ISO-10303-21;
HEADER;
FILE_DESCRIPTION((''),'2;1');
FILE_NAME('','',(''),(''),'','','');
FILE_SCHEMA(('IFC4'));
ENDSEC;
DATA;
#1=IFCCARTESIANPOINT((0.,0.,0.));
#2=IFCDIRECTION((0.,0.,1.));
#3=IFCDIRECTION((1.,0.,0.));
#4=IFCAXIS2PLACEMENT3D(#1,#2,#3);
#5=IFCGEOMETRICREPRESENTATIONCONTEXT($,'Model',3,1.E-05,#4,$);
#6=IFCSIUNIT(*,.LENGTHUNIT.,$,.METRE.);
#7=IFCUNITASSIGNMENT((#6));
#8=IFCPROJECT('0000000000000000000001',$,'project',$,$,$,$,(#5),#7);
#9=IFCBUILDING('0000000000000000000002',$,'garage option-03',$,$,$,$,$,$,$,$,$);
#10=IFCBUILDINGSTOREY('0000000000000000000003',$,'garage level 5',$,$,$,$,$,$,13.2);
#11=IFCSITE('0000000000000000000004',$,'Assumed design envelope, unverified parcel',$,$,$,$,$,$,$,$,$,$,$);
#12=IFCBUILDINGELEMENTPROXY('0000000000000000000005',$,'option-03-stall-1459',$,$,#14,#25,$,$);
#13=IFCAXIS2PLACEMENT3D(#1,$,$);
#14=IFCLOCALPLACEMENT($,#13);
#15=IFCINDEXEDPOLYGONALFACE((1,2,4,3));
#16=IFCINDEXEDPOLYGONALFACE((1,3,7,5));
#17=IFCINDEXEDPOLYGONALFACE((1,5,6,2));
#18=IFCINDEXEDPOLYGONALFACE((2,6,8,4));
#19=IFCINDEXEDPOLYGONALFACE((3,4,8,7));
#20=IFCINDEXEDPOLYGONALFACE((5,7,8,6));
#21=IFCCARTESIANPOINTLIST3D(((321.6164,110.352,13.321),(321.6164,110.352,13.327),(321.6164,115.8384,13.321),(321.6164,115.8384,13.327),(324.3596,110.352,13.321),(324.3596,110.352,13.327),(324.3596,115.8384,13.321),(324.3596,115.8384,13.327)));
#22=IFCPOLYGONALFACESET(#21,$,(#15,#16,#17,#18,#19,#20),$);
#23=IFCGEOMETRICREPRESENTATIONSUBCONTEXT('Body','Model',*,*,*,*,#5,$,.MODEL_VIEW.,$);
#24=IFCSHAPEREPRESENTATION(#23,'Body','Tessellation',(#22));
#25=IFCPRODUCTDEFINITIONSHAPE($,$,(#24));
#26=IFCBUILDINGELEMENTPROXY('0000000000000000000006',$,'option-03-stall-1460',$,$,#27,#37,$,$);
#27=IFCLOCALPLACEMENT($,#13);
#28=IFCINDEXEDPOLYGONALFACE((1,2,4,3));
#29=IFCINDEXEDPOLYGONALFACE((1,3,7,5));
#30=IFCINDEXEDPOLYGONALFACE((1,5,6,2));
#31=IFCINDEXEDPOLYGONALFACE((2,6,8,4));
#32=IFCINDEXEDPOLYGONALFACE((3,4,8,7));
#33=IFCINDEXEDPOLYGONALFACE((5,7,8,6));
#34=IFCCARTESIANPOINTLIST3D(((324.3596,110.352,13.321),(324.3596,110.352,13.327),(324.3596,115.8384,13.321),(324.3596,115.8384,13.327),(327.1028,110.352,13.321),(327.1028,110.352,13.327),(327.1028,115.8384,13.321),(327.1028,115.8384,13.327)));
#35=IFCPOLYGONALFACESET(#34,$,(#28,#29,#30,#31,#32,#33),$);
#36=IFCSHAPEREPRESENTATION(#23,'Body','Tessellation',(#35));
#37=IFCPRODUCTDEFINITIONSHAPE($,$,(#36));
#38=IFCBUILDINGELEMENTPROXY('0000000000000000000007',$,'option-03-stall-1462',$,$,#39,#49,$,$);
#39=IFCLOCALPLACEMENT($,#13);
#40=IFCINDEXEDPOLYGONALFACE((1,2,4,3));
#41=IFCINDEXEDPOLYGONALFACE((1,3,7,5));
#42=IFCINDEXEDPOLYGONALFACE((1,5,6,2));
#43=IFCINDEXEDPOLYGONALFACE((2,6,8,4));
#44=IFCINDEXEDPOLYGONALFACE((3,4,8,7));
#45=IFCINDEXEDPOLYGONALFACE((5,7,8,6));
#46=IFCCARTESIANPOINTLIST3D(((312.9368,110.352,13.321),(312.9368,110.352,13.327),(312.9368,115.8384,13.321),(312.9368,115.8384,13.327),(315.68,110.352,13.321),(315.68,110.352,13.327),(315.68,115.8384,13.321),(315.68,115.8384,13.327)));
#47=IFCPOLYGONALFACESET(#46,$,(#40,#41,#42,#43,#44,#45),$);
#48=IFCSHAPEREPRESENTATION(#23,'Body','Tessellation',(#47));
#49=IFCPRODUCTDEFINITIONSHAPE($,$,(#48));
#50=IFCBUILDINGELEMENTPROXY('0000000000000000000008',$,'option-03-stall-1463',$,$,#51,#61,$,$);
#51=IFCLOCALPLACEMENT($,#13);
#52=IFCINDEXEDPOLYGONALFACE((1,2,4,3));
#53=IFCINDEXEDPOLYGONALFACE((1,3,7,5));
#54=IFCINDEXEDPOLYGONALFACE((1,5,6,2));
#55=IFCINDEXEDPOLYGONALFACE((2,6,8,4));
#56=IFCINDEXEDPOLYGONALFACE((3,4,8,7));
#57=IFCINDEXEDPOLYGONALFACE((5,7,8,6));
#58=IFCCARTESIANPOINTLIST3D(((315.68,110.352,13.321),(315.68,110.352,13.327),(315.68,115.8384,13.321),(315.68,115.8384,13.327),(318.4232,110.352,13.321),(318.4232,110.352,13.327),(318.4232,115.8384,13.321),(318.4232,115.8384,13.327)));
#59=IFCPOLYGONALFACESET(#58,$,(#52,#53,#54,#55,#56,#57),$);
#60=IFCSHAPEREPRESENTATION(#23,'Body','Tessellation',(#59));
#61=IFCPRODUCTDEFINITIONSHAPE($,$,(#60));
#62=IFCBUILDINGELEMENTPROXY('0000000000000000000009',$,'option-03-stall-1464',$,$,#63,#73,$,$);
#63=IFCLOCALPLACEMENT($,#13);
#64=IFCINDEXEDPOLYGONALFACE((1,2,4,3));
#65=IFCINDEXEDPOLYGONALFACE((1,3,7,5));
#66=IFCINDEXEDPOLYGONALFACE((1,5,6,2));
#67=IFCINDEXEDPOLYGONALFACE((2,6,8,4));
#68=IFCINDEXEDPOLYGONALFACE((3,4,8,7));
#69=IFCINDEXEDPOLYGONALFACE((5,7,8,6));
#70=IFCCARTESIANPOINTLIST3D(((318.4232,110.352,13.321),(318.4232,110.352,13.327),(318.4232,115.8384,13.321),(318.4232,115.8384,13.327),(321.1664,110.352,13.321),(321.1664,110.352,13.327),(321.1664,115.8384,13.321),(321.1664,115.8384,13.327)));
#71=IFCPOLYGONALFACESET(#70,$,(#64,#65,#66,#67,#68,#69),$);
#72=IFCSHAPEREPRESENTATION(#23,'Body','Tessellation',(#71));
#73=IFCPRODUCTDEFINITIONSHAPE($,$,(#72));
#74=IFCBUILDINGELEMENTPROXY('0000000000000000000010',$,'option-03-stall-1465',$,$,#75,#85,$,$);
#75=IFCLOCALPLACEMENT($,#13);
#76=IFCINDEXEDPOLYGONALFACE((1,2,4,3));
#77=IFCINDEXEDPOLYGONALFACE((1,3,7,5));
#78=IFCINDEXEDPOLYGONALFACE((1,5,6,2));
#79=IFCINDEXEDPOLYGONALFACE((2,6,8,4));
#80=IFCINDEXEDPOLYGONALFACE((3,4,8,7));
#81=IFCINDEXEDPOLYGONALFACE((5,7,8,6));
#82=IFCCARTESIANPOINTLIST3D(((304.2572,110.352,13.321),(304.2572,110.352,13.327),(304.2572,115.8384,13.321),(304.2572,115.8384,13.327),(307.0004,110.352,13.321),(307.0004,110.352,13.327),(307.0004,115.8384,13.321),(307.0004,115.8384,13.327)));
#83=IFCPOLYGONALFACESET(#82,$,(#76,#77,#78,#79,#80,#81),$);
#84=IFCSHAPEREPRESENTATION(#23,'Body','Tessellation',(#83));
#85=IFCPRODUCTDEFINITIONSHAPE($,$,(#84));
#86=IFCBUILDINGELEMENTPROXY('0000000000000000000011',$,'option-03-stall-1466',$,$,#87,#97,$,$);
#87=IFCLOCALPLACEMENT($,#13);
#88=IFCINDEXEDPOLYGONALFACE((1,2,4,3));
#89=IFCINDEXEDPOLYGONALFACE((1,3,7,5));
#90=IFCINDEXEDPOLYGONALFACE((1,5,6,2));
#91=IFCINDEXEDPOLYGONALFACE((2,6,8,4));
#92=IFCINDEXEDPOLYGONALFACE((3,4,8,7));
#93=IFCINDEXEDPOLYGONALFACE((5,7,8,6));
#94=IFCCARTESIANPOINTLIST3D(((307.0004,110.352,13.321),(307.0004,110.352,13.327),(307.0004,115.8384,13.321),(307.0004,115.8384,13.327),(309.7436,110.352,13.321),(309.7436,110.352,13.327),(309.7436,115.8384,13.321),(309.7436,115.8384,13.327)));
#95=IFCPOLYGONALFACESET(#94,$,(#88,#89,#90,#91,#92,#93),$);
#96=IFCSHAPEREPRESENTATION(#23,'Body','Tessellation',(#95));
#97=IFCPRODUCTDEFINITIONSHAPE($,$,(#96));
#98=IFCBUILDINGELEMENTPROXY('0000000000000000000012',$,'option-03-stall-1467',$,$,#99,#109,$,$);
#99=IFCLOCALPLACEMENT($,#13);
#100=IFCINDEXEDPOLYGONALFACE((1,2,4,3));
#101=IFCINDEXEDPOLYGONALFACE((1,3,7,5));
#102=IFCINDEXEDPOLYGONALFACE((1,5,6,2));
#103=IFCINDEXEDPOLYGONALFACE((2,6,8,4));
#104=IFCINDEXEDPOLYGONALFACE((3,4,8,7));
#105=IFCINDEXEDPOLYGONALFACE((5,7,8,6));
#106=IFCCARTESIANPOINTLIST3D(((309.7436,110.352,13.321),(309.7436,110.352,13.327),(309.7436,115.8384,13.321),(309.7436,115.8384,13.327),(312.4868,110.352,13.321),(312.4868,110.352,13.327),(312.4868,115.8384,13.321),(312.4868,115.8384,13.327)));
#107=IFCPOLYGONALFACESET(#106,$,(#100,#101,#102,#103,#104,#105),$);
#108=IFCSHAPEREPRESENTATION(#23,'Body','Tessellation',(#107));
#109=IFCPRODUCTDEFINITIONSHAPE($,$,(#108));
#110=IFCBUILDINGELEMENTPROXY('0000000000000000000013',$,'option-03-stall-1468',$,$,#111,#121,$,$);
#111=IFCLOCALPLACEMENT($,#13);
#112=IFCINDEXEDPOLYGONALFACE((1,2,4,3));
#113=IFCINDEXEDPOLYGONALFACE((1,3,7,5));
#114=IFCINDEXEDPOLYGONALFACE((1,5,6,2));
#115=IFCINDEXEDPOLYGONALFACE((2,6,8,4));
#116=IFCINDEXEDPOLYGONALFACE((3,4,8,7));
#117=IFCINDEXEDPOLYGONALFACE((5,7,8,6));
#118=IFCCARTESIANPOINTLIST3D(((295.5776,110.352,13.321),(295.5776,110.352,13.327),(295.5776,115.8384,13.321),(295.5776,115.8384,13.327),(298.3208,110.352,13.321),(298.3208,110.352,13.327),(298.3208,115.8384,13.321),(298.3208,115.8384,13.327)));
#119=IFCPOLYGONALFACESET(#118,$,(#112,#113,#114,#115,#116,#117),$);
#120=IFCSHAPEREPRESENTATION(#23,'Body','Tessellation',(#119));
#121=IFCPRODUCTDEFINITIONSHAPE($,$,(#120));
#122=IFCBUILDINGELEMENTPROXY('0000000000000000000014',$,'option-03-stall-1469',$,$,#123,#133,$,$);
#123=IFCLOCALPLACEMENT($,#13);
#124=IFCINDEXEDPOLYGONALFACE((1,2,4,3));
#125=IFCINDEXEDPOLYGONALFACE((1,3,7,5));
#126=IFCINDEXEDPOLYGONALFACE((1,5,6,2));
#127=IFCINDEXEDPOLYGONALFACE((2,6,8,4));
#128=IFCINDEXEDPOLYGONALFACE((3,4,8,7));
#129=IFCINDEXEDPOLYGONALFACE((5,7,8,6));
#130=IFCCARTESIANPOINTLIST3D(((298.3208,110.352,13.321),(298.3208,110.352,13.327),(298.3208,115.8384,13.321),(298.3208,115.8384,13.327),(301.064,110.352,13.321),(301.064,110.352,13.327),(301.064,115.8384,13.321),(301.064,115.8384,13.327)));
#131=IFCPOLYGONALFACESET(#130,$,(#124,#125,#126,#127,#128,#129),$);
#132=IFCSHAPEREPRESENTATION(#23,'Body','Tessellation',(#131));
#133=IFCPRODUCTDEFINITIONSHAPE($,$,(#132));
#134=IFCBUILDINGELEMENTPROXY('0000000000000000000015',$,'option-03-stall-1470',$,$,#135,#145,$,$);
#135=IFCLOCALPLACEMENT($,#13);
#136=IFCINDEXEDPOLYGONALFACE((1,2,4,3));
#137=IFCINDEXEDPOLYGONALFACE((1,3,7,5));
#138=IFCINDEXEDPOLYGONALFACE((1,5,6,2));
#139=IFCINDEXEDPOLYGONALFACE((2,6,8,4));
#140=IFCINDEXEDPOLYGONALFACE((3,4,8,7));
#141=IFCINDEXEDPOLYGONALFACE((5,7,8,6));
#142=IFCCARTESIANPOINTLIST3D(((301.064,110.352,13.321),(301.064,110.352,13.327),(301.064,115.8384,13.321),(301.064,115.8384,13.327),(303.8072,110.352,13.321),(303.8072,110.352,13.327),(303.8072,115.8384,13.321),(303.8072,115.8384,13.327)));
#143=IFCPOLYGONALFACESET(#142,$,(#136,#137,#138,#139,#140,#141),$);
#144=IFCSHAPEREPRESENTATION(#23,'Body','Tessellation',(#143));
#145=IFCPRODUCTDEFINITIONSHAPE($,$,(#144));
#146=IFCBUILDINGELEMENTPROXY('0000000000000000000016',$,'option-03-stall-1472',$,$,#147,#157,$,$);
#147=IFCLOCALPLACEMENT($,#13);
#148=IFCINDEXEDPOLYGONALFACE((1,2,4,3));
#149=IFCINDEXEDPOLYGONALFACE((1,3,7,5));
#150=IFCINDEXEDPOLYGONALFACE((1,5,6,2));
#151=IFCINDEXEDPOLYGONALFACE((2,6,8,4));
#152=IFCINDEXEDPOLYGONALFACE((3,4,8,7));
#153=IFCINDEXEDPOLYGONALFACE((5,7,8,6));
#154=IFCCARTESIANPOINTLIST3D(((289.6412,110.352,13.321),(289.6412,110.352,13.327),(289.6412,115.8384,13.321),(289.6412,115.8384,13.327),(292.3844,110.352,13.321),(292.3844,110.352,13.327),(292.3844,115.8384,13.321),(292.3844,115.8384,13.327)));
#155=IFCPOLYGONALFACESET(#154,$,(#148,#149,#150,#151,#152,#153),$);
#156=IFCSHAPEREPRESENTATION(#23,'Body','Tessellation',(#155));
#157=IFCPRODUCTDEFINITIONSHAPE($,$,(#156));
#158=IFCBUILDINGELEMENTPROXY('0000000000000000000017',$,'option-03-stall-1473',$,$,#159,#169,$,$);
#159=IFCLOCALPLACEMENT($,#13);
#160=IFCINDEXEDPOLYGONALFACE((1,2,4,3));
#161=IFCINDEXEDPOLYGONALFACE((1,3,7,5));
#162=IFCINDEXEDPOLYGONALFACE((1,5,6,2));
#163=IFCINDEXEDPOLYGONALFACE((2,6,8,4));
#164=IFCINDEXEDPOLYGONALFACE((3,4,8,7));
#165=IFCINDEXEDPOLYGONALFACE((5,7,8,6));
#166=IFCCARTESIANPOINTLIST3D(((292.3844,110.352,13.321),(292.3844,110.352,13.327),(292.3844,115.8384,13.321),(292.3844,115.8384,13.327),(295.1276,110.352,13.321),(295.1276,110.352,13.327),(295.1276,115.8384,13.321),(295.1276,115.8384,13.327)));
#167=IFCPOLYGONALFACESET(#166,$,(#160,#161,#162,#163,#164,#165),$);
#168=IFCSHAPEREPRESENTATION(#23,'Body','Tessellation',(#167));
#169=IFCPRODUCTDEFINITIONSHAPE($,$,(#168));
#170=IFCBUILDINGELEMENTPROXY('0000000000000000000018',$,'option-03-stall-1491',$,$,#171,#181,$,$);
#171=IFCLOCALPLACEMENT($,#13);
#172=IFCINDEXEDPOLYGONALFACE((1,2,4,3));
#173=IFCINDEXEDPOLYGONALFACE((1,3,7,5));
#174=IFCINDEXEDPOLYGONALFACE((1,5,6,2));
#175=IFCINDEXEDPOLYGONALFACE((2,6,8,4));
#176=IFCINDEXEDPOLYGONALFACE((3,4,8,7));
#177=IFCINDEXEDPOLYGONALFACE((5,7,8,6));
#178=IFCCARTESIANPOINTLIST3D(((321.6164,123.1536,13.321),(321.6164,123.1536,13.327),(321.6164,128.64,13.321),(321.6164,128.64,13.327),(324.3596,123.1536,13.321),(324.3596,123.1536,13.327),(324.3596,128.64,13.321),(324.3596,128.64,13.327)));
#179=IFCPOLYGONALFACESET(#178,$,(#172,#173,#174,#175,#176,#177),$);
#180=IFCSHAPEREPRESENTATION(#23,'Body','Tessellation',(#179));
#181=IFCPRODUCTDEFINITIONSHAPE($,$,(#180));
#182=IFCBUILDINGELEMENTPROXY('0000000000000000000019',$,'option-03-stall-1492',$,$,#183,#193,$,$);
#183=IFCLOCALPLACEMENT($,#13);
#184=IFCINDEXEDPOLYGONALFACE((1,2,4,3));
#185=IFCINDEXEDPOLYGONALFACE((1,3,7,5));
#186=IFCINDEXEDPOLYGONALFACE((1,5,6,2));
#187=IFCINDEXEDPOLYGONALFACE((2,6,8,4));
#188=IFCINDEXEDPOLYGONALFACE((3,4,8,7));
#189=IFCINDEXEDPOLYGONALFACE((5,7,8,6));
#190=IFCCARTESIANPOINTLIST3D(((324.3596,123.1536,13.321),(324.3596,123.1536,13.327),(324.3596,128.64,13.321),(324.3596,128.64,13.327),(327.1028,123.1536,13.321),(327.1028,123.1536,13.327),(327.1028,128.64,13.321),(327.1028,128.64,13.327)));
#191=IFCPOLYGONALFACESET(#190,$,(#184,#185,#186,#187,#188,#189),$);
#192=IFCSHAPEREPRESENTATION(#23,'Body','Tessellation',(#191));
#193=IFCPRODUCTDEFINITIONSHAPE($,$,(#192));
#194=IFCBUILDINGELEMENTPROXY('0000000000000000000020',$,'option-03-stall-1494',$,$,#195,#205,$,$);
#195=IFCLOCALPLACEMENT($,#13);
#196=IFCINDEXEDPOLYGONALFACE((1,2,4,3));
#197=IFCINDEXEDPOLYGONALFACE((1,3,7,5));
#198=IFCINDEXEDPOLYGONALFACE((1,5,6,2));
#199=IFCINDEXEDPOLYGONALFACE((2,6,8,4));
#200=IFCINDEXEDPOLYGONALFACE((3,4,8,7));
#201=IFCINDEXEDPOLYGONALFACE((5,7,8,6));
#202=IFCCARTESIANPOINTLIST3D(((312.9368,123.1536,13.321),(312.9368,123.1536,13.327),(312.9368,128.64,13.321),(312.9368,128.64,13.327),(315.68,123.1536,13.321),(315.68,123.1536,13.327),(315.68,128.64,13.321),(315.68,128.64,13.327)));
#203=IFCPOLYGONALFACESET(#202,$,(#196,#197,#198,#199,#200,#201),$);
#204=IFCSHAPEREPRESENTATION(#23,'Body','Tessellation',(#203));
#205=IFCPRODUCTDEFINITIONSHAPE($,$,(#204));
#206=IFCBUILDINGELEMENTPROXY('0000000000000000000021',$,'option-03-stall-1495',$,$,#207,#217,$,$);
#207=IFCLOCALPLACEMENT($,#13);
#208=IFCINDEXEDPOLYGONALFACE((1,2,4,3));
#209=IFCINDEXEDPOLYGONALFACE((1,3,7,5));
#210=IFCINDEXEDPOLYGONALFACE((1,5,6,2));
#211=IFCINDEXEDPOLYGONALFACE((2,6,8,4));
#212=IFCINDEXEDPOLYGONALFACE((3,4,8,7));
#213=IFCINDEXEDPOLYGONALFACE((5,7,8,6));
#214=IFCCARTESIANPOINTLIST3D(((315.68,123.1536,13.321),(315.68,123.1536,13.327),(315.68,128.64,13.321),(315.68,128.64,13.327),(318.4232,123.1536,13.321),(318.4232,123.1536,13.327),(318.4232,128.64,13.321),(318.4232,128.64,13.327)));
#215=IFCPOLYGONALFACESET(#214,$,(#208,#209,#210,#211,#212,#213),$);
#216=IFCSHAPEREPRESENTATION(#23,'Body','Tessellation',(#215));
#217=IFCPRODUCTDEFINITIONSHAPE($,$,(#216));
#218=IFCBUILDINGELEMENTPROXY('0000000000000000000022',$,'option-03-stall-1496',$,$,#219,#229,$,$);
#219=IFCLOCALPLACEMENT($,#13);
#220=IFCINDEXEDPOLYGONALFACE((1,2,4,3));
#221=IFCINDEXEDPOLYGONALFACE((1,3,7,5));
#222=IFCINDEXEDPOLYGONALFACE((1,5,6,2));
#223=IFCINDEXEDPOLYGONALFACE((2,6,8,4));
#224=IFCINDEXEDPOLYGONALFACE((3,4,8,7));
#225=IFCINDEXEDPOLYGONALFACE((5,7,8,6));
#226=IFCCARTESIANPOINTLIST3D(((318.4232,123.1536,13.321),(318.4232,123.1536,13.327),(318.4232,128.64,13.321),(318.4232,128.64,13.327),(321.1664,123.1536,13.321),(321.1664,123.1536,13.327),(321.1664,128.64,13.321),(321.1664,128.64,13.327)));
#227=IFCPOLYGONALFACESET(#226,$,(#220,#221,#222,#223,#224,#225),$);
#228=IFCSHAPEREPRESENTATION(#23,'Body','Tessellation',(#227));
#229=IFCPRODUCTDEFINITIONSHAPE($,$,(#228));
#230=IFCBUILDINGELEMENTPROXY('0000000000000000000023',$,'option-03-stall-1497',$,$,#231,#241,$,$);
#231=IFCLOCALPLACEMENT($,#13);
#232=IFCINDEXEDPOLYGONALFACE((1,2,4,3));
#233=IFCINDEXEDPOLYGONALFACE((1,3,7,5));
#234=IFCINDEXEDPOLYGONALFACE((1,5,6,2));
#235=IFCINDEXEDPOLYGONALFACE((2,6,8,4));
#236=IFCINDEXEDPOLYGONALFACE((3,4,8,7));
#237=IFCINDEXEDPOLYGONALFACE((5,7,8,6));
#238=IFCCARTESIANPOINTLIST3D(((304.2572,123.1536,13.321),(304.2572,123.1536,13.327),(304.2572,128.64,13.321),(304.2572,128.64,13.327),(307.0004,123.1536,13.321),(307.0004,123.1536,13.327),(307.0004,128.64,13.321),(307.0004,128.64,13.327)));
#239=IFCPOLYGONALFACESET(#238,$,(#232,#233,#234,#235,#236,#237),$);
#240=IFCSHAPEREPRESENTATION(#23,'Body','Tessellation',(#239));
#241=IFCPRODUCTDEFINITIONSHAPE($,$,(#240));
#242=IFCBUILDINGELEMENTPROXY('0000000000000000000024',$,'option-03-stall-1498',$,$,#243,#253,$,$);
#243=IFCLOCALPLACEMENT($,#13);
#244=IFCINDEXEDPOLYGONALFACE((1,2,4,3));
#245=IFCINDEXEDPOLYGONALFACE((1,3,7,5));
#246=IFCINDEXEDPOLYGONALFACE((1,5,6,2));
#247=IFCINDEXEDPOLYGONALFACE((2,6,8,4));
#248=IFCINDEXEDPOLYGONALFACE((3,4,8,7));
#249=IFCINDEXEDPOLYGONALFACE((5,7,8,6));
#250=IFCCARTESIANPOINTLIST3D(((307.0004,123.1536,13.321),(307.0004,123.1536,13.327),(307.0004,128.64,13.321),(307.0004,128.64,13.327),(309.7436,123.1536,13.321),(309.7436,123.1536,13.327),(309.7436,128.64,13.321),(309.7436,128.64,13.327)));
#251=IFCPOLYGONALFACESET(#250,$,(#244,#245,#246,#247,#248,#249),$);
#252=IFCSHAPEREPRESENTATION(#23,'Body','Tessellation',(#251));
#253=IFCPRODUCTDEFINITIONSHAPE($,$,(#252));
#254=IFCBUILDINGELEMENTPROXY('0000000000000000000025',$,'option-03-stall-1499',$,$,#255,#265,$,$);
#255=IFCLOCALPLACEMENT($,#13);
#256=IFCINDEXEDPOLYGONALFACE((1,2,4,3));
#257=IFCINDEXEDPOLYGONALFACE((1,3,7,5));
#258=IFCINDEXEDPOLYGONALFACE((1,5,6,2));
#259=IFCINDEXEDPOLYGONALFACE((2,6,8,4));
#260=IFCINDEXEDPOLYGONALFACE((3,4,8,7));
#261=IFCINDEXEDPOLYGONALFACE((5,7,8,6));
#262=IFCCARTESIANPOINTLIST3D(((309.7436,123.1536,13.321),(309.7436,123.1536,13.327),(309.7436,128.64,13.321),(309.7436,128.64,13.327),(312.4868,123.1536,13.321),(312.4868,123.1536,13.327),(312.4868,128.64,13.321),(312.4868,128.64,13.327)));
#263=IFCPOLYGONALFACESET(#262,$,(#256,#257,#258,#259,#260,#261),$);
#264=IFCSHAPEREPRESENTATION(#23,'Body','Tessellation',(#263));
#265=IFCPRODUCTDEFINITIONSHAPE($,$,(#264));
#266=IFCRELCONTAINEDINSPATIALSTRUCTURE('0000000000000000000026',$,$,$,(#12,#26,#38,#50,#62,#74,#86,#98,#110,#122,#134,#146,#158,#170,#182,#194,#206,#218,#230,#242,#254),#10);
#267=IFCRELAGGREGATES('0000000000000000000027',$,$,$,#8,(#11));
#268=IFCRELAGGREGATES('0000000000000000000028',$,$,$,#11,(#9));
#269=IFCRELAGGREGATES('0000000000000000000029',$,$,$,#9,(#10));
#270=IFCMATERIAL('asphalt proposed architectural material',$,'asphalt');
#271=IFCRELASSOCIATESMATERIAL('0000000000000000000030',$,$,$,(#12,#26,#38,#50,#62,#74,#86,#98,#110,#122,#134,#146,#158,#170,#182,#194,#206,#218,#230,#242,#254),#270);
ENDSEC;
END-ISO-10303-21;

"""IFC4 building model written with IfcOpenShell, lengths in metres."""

from ifc_helpers import new_model, si_unit, frame, origin_with_axes, place, context, subcontext, project, spatial, rectangle, extrude, material, element, save


model = new_model("IFC4")

# Units and contexts
model_context = context("Model", 3, precision=1e-05, world=origin_with_axes())
body_context = subcontext(model_context, "Body", "Model", "MODEL_VIEW")
ifc_project = project(units=[si_unit("LENGTHUNIT", "METRE")], contexts=[model_context])

# Site, building, storey
site = spatial("IfcSite", under=ifc_project, Name="Assumed design envelope, unverified parcel")
building = spatial("IfcBuilding", under=site, Name="garage option-03")
storey = spatial("IfcBuildingStorey", under=building, Name="garage level 5", Elevation=13.2)

# Building element proxies
ifc_material_1 = material(Name="asphalt proposed architectural material", Category="asphalt")
for number, where, z_axis, x_axis, name in (
    (1, (322.988, 113.0952, 13.321), (0.0, 0.0, 1.0), (1.0, 0.0, 0.0), "option-03-stall-1459"),
    (2, (325.7312, 113.0952, 13.321), (0.0, 0.0, 1.0), (1.0, 0.0, 0.0), "option-03-stall-1460"),
    (3, (314.3084, 113.0952, 13.321), (0.0, 0.0, 1.0), (1.0, 0.0, 0.0), "option-03-stall-1462"),
    (4, (317.0516, 113.0952, 13.321), (0.0, 0.0, 1.0), (1.0, 0.0, 0.0), "option-03-stall-1463"),
    (5, (319.7948, 113.0952, 13.321), (0.0, 0.0, 1.0), (1.0, 0.0, 0.0), "option-03-stall-1464"),
    (6, (305.6288, 113.0952, 13.321), (0.0, 0.0, 1.0), (1.0, 0.0, 0.0), "option-03-stall-1465"),
    (7, (308.372, 113.0952, 13.321), (0.0, 0.0, 1.0), (1.0, 0.0, 0.0), "option-03-stall-1466"),
    (8, (311.1152, 113.0952, 13.321), (0.0, 0.0, 1.0), (1.0, 0.0, 0.0), "option-03-stall-1467"),
    (9, (296.9492, 113.0952, 13.321), (0.0, 0.0, 1.0), (1.0, 0.0, 0.0), "option-03-stall-1468"),
    (10, (299.6924, 113.0952, 13.321), (0.0, 0.0, 1.0), (1.0, 0.0, 0.0), "option-03-stall-1469"),
    (11, (302.4356, 113.0952, 13.321), (0.0, 0.0, 1.0), (1.0, 0.0, 0.0), "option-03-stall-1470"),
    (12, (291.0128, 113.0952, 13.321), (0.0, 0.0, 1.0), (1.0, 0.0, 0.0), "option-03-stall-1472"),
    (13, (293.756, 113.0952, 13.321), (0.0, 0.0, 1.0), (1.0, 0.0, 0.0), "option-03-stall-1473"),
):
    element("IfcBuildingElementProxy", number, at=place(None, frame(where, z_axis=z_axis, x_axis=x_axis)), inside=storey, material=ifc_material_1, Name=name, context=body_context, shape_type="SweptSolid", body=[
        extrude(rectangle(XDim=2.7432, YDim=5.4864), origin_with_axes(), (0.0, 0.0, 1.0), 0.006),
    ])
for number, where, z_axis, x_axis, name in (
    (14, (322.988, 125.8968, 13.321), (0.0, 0.0, 1.0), (1.0, 0.0, 0.0), "option-03-stall-1491"),
    (15, (325.7312, 125.8968, 13.321), (0.0, 0.0, 1.0), (1.0, 0.0, 0.0), "option-03-stall-1492"),
    (16, (314.3084, 125.8968, 13.321), (0.0, 0.0, 1.0), (1.0, 0.0, 0.0), "option-03-stall-1494"),
    (17, (317.0516, 125.8968, 13.321), (0.0, 0.0, 1.0), (1.0, 0.0, 0.0), "option-03-stall-1495"),
    (18, (319.7948, 125.8968, 13.321), (0.0, 0.0, 1.0), (1.0, 0.0, 0.0), "option-03-stall-1496"),
    (19, (305.6288, 125.8968, 13.321), (0.0, 0.0, 1.0), (1.0, 0.0, 0.0), "option-03-stall-1497"),
    (20, (308.372, 125.8968, 13.321), (0.0, 0.0, 1.0), (1.0, 0.0, 0.0), "option-03-stall-1498"),
    (21, (311.1152, 125.8968, 13.321), (0.0, 0.0, 1.0), (1.0, 0.0, 0.0), "option-03-stall-1499"),
):
    element("IfcBuildingElementProxy", number, at=place(None, frame(where, z_axis=z_axis, x_axis=x_axis)), inside=storey, material=ifc_material_1, Name=name, context=body_context, shape_type="SweptSolid", body=[
        extrude(rectangle(XDim=2.7432, YDim=5.4864), origin_with_axes(), (0.0, 0.0, 1.0), 0.006),
    ])

save(model, "model.ifc")
